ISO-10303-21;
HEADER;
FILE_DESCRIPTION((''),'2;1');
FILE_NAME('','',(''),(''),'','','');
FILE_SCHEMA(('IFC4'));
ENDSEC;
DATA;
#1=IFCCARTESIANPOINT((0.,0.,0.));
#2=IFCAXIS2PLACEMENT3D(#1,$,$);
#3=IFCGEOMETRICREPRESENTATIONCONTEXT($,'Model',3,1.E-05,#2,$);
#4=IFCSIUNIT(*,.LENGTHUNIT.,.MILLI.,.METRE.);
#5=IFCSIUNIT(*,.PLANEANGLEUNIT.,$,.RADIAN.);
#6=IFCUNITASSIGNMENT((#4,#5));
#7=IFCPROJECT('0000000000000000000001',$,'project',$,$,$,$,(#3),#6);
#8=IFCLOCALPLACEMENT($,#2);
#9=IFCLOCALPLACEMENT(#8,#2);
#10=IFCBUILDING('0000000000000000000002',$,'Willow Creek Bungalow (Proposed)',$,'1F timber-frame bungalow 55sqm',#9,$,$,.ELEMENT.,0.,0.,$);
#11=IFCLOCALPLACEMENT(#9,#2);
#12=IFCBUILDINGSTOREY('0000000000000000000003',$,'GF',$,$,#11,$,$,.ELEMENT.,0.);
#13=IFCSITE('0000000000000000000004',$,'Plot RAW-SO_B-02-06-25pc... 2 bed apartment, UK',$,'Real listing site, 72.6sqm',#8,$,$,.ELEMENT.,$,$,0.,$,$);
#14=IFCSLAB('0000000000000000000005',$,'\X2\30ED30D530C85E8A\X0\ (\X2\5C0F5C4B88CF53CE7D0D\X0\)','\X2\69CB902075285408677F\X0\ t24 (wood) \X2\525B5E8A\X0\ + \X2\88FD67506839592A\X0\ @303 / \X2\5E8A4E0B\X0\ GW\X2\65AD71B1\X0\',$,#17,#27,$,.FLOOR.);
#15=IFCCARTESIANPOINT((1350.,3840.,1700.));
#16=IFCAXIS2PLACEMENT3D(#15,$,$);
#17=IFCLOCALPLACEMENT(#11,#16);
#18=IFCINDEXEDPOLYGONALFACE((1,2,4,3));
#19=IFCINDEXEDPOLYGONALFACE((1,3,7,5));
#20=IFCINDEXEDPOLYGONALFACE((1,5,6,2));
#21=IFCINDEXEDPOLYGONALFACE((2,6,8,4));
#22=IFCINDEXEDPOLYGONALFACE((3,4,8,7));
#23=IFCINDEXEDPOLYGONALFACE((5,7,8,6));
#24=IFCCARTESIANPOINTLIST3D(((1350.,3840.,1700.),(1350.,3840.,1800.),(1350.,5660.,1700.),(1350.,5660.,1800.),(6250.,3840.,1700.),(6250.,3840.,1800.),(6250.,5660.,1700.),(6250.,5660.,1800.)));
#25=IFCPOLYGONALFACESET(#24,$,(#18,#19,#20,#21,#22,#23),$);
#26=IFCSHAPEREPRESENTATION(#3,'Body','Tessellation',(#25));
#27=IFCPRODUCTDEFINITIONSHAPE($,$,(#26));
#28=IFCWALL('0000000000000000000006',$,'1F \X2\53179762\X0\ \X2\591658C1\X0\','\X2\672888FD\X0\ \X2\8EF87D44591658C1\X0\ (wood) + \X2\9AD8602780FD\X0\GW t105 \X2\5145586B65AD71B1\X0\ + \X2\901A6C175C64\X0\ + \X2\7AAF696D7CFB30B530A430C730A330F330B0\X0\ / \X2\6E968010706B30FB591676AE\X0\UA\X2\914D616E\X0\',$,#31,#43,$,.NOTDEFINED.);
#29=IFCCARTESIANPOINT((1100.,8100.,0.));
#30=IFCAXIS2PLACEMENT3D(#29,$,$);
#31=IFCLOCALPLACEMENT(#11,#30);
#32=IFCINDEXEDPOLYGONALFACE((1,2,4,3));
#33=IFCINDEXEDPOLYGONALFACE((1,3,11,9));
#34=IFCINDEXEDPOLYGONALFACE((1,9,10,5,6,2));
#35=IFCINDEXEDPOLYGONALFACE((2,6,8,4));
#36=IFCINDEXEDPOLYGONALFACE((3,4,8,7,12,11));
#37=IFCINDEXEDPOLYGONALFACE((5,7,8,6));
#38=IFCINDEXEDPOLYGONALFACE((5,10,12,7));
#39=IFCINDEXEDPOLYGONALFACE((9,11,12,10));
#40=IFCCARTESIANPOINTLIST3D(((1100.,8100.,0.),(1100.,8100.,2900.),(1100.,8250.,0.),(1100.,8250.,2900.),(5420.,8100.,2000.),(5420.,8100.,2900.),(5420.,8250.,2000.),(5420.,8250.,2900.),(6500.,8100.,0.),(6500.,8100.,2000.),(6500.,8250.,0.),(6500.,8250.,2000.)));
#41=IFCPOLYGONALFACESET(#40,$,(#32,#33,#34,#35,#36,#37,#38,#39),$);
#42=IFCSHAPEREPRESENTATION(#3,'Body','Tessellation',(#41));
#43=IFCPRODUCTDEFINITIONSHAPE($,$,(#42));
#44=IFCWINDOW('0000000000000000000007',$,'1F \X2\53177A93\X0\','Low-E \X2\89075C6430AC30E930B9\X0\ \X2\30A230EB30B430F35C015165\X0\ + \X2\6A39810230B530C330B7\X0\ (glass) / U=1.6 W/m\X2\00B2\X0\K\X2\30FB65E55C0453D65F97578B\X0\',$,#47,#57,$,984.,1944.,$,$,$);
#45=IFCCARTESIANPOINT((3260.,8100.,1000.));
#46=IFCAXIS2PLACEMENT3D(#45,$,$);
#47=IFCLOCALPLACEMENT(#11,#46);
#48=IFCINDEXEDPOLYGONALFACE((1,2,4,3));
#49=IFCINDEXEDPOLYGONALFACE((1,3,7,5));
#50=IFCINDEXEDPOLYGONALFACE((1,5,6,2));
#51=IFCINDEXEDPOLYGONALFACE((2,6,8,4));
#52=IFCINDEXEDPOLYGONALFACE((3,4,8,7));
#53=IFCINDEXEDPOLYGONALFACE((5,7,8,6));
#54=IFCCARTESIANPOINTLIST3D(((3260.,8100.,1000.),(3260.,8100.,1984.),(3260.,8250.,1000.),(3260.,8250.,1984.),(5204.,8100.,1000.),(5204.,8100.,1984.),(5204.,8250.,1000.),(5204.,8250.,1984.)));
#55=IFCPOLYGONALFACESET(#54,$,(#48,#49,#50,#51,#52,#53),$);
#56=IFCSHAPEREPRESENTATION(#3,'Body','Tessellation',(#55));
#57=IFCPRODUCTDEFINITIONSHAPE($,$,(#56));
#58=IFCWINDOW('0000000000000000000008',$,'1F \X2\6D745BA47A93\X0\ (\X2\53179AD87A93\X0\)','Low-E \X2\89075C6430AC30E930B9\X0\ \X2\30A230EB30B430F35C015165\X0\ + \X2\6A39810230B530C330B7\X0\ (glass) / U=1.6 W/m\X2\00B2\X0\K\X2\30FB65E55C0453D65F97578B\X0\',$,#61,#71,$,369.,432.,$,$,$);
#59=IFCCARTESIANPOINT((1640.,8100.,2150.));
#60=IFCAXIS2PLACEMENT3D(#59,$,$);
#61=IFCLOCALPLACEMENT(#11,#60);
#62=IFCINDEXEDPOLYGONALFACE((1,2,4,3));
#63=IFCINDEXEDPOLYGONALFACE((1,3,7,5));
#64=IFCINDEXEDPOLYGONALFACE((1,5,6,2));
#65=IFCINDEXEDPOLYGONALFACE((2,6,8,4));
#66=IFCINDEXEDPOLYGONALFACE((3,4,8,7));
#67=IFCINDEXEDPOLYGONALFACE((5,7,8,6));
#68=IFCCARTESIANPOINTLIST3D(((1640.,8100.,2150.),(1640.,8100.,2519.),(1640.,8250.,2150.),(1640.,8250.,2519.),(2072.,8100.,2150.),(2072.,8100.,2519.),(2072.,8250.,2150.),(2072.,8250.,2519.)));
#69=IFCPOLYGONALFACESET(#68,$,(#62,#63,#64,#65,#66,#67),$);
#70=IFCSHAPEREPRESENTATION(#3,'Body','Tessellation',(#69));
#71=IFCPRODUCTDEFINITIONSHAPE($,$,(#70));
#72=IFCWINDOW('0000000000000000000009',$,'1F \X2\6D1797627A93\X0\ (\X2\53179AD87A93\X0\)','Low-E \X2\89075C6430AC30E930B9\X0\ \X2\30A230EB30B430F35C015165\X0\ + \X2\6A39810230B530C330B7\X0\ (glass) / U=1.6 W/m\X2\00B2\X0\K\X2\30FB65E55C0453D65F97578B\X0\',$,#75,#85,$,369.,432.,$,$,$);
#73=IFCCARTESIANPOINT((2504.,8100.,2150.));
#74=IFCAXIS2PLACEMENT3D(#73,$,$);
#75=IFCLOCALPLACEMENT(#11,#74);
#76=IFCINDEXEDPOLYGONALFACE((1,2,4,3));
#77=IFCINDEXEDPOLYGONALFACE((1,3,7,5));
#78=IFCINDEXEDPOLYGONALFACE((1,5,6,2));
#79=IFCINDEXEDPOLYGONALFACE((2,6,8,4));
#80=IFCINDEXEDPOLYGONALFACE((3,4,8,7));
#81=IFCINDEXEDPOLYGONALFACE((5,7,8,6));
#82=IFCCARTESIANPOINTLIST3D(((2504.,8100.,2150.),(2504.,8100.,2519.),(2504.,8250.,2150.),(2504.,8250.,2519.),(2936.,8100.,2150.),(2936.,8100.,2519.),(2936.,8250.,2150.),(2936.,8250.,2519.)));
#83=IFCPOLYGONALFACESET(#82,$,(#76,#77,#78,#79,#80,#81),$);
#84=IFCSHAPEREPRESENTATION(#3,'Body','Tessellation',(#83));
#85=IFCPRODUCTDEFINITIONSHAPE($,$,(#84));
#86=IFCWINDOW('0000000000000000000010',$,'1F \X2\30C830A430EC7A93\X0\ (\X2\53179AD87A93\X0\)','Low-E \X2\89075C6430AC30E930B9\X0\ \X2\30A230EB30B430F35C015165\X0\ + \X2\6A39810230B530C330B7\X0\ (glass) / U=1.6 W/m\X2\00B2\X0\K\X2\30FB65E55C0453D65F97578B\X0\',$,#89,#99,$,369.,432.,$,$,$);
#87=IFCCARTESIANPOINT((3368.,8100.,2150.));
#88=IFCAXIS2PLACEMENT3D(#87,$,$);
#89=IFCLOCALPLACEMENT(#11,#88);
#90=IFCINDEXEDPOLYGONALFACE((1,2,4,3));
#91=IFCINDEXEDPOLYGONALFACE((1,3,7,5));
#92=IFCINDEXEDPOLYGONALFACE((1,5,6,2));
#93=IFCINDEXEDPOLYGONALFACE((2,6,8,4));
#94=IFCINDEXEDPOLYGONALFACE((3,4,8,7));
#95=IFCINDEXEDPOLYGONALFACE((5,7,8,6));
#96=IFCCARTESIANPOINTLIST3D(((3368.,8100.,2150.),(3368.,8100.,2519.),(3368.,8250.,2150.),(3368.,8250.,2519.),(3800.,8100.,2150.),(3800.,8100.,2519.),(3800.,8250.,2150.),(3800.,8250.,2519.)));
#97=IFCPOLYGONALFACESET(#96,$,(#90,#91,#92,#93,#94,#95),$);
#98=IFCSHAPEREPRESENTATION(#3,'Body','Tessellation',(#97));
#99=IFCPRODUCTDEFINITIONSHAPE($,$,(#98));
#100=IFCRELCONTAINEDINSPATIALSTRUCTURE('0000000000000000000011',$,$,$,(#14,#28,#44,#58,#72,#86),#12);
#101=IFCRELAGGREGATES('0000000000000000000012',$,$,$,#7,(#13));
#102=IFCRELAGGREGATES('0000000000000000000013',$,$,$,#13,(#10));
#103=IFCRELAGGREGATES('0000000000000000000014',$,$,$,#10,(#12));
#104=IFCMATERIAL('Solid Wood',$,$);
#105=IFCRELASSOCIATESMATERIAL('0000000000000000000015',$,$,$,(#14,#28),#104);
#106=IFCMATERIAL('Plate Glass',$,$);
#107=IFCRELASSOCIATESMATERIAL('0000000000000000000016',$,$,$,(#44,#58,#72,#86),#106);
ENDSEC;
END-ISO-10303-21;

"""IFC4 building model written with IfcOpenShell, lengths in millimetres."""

from ifc_helpers import new_model, si_unit, frame, frame_2d, origin, place, context, project, spatial, rectangle, extrude, material, element, fill, save


model = new_model("IFC4")

# Units and contexts
model_context = context("Model", 3, precision=1e-05, world=origin())
ifc_project = project(units=[si_unit("LENGTHUNIT", "METRE", prefix="MILLI"), si_unit("PLANEANGLEUNIT", "RADIAN")], contexts=[model_context])

# Site, building, storey
site_placement = place(None, origin())
site = spatial("IfcSite", under=ifc_project, at=site_placement, Name="Plot RAW-SO_B-02-06-25pc... 2 bed apartment, UK", ObjectType="Real listing site, 72.6sqm", CompositionType="ELEMENT", RefElevation=0.0)
building_placement = place(site_placement, origin())
building = spatial("IfcBuilding", under=site, at=building_placement, Name="Willow Creek Bungalow (Proposed)", ObjectType="1F timber-frame bungalow 55sqm", CompositionType="ELEMENT", ElevationOfRefHeight=0.0, ElevationOfTerrain=0.0)
storey_placement = place(building_placement, origin())
storey = spatial("IfcBuildingStorey", under=building, at=storey_placement, Name="GF", CompositionType="ELEMENT", Elevation=0.0)

# Slab
ifc_material_1 = material(Name="Solid Wood")
slab_placement = place(storey_placement, frame((1350.0, 3840.0, 1700.0)))
element("IfcSlab", 1, at=slab_placement, inside=storey, material=ifc_material_1, Name="ロフト床 (小屋裏収納)", Description="構造用合板 t24 (wood) 剛床 + 製材根太 @303 / 床下 GW断熱", PredefinedType="FLOOR", context=model_context, shape_type="SweptSolid", body=[
    extrude(rectangle(XDim=4900.0, YDim=1820.0, at=frame_2d((2450.0, 910.0))), frame((1350.0, 3840.0, 1700.0)), (0.0, 0.0, 1.0), 100.0),
])

# Wall, openings, windows
wall_1_placement = place(storey_placement, frame((1100.0, 8100.0, 0.0)))
wall_1 = element("IfcWall", 2, at=wall_1_placement, inside=storey, material=ifc_material_1, Name="1F 北面 外壁", Description="木製 軸組外壁 (wood) + 高性能GW t105 充填断熱 + 通気層 + 窯業系サイディング / 準耐火・外皮UA配慮", PredefinedType="NOTDEFINED", context=model_context, shape_type="SweptSolid", body=[
    extrude(rectangle(XDim=5400.0, YDim=150.0, at=frame_2d((2700.0, 75.0))), frame((1100.0, 8100.0, 0.0)), (0.0, 0.0, 1.0), 2900.0),
])
opening_1_placement = place(storey_placement, frame((3260.0, 8100.0, 1000.0)))
opening_1 = element("IfcOpeningElement", 3, at=opening_1_placement, cuts=wall_1, PredefinedType="NOTDEFINED", context=model_context, shape_type="SweptSolid", body=[
    extrude(rectangle(XDim=1944.0, YDim=150.0, at=frame_2d((972.0, 75.0))), frame((3260.0, 8100.0, 1000.0)), (0.0, 0.0, 1.0), 984.0),
])
opening_2_placement = place(storey_placement, frame((1640.0, 8100.0, 2150.0)))
opening_2 = element("IfcOpeningElement", 4, at=opening_2_placement, cuts=wall_1, PredefinedType="NOTDEFINED", context=model_context, shape_type="SweptSolid", body=[
    extrude(rectangle(XDim=432.0, YDim=150.0, at=frame_2d((216.0, 75.0))), frame((1640.0, 8100.0, 2150.0)), (0.0, 0.0, 1.0), 369.0),
])
opening_3_placement = place(storey_placement, frame((2504.0, 8100.0, 2150.0)))
opening_3 = element("IfcOpeningElement", 5, at=opening_3_placement, cuts=wall_1, PredefinedType="NOTDEFINED", context=model_context, shape_type="SweptSolid", body=[
    extrude(rectangle(XDim=432.0, YDim=150.0, at=frame_2d((216.0, 75.0))), frame((2504.0, 8100.0, 2150.0)), (0.0, 0.0, 1.0), 369.0),
])
opening_4_placement = place(storey_placement, frame((3368.0, 8100.0, 2150.0)))
opening_4 = element("IfcOpeningElement", 6, at=opening_4_placement, cuts=wall_1, PredefinedType="NOTDEFINED", context=model_context, shape_type="SweptSolid", body=[
    extrude(rectangle(XDim=432.0, YDim=150.0, at=frame_2d((216.0, 75.0))), frame((3368.0, 8100.0, 2150.0)), (0.0, 0.0, 1.0), 369.0),
])
ifc_material_2 = material(Name="Plate Glass")
window_1_placement = place(storey_placement, frame((3260.0, 8100.0, 1000.0)))
window_1 = element("IfcWindow", 7, at=window_1_placement, inside=storey, material=ifc_material_2, Name="1F 北窓", Description="Low-E 複層ガラス アルゴン封入 + 樹脂サッシ (glass) / U=1.6 W/m²K・日射取得型", OverallHeight=984.0, OverallWidth=1944.0, context=model_context, shape_type="SweptSolid", body=[
    extrude(rectangle(XDim=1944.0, YDim=150.0, at=frame_2d((972.0, 75.0))), frame((3260.0, 8100.0, 1000.0)), (0.0, 0.0, 1.0), 984.0),
])
fill(opening_1, window_1)
window_2_placement = place(storey_placement, frame((1640.0, 8100.0, 2150.0)))
window_2 = element("IfcWindow", 8, at=window_2_placement, inside=storey, material=ifc_material_2, Name="1F 浴室窓 (北高窓)", Description="Low-E 複層ガラス アルゴン封入 + 樹脂サッシ (glass) / U=1.6 W/m²K・日射取得型", OverallHeight=369.0, OverallWidth=432.0, context=model_context, shape_type="SweptSolid", body=[
    extrude(rectangle(XDim=432.0, YDim=150.0, at=frame_2d((216.0, 75.0))), frame((1640.0, 8100.0, 2150.0)), (0.0, 0.0, 1.0), 369.0),
])
fill(opening_2, window_2)
window_3_placement = place(storey_placement, frame((2504.0, 8100.0, 2150.0)))
window_3 = element("IfcWindow", 9, at=window_3_placement, inside=storey, material=ifc_material_2, Name="1F 洗面窓 (北高窓)", Description="Low-E 複層ガラス アルゴン封入 + 樹脂サッシ (glass) / U=1.6 W/m²K・日射取得型", OverallHeight=369.0, OverallWidth=432.0, context=model_context, shape_type="SweptSolid", body=[
    extrude(rectangle(XDim=432.0, YDim=150.0, at=frame_2d((216.0, 75.0))), frame((2504.0, 8100.0, 2150.0)), (0.0, 0.0, 1.0), 369.0),
])
fill(opening_3, window_3)
window_4_placement = place(storey_placement, frame((3368.0, 8100.0, 2150.0)))
window_4 = element("IfcWindow", 10, at=window_4_placement, inside=storey, material=ifc_material_2, Name="1F トイレ窓 (北高窓)", Description="Low-E 複層ガラス アルゴン封入 + 樹脂サッシ (glass) / U=1.6 W/m²K・日射取得型", OverallHeight=369.0, OverallWidth=432.0, context=model_context, shape_type="SweptSolid", body=[
    extrude(rectangle(XDim=432.0, YDim=150.0, at=frame_2d((216.0, 75.0))), frame((3368.0, 8100.0, 2150.0)), (0.0, 0.0, 1.0), 369.0),
])
fill(opening_4, window_4)

save(model, "model.ifc")
